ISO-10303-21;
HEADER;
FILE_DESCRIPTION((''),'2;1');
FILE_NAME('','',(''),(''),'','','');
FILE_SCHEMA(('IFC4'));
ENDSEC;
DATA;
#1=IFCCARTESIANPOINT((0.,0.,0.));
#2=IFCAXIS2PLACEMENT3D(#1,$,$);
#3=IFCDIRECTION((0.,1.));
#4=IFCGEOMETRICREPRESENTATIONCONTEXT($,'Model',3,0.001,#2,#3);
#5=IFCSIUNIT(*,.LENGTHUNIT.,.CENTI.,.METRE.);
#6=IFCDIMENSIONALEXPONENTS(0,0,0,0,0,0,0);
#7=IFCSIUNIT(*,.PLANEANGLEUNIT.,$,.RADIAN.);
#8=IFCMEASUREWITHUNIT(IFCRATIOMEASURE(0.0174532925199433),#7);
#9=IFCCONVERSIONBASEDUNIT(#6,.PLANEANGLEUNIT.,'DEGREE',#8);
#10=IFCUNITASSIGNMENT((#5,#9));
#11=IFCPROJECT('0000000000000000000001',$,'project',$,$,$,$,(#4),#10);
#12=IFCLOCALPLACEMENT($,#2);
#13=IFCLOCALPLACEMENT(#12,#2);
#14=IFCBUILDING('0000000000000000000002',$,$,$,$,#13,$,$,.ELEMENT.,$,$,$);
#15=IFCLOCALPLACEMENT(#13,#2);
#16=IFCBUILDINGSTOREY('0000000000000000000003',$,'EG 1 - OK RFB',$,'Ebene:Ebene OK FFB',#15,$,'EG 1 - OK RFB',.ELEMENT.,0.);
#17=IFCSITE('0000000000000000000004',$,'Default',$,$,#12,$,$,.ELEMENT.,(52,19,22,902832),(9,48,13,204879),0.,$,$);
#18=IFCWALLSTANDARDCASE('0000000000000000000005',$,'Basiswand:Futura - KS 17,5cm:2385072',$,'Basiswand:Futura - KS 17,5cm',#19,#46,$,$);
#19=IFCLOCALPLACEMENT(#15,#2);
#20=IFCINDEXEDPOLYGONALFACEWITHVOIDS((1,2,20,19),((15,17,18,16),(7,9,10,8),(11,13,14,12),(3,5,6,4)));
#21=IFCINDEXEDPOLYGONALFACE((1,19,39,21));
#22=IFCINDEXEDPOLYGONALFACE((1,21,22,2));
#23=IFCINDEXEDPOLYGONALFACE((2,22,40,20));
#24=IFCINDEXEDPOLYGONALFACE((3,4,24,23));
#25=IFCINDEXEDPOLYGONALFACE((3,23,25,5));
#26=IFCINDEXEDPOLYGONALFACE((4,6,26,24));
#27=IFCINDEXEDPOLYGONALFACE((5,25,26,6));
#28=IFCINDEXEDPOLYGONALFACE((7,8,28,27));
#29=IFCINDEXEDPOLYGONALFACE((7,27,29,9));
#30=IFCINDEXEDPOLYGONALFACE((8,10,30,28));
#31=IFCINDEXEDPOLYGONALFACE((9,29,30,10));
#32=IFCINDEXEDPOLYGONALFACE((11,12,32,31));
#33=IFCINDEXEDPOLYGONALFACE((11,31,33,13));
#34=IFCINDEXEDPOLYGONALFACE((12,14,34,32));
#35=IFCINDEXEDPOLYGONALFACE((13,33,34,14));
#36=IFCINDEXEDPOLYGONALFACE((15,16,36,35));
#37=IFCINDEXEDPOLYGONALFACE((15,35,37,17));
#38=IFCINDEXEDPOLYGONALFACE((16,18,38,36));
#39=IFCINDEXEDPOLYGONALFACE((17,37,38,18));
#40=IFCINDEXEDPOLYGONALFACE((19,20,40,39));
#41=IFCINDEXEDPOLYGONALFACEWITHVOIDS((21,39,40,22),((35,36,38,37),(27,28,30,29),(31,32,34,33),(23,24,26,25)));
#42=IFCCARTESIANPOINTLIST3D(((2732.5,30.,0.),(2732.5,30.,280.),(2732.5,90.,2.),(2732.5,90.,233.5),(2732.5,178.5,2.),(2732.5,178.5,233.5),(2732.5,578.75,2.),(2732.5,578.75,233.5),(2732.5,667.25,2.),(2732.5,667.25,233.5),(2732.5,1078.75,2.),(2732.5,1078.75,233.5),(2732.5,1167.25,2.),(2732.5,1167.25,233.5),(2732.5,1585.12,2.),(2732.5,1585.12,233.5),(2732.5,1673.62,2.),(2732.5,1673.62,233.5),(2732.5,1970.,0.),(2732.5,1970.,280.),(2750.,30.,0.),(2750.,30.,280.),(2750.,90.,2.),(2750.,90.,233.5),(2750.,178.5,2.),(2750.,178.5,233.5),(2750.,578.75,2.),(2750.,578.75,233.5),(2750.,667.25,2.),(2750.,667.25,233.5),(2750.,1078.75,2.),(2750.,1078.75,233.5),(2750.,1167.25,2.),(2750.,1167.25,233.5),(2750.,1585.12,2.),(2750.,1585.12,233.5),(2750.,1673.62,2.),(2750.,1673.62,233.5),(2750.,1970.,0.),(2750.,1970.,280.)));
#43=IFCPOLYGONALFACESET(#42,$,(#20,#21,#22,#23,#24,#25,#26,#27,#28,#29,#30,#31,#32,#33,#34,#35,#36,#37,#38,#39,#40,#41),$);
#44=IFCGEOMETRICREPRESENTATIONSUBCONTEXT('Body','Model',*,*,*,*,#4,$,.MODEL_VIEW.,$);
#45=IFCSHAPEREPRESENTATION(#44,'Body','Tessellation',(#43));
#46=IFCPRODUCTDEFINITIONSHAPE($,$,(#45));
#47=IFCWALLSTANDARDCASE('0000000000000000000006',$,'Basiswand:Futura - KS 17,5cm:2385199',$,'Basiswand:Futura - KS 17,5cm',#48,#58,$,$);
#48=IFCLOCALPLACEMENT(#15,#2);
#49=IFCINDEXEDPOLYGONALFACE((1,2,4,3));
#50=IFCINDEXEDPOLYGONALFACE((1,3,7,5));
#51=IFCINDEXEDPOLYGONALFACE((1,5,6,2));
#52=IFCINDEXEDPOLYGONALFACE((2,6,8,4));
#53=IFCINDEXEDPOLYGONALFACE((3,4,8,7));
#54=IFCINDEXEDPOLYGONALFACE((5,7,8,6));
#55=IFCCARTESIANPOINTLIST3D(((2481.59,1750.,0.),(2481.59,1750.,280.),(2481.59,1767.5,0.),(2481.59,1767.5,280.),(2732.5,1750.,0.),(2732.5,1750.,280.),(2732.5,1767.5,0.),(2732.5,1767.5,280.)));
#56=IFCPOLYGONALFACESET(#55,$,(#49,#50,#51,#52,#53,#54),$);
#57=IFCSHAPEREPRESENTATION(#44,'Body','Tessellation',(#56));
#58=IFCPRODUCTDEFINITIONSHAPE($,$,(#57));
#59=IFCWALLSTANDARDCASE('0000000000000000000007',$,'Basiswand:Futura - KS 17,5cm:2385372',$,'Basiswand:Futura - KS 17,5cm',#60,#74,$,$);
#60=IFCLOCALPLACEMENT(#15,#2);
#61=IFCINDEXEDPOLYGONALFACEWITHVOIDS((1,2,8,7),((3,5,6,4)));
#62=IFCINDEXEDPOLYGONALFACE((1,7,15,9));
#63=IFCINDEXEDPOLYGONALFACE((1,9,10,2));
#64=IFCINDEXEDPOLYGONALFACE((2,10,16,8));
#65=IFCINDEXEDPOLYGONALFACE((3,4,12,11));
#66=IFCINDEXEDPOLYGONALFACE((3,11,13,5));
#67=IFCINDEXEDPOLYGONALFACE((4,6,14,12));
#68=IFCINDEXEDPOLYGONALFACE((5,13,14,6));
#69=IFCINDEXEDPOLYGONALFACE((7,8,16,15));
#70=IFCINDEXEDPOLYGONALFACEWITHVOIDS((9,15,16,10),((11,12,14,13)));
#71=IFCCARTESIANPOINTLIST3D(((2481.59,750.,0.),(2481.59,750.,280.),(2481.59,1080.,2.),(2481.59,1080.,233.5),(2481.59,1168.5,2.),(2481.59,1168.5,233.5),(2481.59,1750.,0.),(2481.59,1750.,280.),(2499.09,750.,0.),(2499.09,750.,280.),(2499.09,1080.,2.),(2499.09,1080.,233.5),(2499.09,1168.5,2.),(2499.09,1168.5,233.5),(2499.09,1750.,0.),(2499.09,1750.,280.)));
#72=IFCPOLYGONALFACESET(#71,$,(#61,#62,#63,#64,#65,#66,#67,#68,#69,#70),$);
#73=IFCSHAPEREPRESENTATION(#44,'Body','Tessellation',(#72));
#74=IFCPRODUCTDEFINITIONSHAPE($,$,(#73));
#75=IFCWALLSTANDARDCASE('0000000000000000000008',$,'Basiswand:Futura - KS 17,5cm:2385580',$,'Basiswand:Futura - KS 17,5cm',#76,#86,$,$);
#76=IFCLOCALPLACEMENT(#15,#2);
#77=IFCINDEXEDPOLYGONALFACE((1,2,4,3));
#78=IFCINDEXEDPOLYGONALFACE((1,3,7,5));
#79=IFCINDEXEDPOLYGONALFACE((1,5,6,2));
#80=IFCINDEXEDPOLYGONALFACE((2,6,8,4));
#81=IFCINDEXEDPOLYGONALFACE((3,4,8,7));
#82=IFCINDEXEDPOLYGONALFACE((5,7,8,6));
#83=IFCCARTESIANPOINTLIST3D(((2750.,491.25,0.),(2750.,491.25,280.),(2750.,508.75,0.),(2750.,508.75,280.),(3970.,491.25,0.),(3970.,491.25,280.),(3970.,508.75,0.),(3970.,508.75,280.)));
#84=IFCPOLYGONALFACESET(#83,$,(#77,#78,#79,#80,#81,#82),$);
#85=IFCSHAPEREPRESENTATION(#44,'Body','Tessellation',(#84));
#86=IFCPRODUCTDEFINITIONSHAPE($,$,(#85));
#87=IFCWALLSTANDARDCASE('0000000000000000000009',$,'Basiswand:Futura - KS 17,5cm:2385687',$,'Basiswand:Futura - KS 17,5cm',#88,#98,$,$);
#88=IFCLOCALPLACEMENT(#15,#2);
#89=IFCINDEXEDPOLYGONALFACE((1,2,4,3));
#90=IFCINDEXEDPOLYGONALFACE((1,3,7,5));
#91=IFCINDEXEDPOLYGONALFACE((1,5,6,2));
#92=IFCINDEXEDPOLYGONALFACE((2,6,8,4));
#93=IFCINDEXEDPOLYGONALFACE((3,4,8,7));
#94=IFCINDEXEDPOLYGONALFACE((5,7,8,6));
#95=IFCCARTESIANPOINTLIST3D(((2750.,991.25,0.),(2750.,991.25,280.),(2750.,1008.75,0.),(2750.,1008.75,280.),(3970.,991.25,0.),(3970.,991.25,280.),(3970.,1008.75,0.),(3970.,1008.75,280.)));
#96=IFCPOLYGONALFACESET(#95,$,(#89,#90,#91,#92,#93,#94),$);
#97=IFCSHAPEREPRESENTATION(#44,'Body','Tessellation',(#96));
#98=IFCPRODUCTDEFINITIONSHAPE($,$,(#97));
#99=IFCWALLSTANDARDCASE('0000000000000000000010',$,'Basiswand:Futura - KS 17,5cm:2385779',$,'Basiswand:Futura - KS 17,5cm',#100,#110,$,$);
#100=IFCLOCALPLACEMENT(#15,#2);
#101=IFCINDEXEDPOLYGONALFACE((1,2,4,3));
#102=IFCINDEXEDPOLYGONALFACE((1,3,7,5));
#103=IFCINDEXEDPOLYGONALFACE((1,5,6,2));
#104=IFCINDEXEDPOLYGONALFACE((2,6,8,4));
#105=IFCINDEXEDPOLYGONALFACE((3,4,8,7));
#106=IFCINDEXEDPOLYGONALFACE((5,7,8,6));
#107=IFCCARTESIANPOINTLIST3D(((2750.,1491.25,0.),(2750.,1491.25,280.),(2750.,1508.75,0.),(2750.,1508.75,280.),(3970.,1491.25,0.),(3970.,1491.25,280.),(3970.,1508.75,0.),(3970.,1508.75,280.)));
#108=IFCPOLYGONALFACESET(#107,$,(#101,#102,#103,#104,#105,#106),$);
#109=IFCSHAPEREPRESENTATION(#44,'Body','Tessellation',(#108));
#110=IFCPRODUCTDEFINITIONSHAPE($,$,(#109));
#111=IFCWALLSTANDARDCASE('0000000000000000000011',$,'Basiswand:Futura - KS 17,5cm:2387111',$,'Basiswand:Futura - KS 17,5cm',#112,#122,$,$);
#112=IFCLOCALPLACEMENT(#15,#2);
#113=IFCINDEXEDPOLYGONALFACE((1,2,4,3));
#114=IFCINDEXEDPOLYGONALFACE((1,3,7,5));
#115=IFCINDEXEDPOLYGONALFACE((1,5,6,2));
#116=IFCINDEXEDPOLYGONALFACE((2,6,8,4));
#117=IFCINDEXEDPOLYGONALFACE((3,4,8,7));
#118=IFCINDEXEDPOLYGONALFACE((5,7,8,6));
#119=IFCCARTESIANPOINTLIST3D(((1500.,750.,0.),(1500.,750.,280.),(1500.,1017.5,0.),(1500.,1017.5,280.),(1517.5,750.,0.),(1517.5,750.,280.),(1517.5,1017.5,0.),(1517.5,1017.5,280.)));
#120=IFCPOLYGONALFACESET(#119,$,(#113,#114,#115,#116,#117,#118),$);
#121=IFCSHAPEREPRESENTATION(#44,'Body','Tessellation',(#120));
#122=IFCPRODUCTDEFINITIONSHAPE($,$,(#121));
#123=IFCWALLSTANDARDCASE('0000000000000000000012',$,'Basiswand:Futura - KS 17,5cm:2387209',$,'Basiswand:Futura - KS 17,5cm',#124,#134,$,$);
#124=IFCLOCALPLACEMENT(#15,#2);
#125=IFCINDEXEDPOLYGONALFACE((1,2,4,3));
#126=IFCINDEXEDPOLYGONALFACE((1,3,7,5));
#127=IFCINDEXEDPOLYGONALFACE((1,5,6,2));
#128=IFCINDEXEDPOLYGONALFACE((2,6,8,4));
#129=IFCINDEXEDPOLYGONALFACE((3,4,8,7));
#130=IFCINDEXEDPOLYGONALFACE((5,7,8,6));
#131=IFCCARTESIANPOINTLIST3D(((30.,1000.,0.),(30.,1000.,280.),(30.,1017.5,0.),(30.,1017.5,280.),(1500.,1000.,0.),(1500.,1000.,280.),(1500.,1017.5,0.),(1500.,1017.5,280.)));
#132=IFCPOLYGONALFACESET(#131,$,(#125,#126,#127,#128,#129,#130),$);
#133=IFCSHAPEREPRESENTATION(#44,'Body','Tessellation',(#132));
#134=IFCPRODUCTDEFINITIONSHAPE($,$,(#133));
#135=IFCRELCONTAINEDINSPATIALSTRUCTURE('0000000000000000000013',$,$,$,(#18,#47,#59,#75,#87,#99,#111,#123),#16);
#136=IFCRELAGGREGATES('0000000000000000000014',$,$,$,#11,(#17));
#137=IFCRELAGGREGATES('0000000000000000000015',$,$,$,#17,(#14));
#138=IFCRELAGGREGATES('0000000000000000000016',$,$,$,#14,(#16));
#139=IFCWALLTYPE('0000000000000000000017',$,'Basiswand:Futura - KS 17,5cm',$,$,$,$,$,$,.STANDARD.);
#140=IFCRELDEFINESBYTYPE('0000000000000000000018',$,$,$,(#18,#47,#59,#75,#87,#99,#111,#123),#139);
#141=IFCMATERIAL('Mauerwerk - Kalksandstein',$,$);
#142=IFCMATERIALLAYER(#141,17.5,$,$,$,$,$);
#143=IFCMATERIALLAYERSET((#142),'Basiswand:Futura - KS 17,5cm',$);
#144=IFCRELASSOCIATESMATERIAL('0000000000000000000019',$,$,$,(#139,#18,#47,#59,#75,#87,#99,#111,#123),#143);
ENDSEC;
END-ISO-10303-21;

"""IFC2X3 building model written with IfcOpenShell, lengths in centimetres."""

from ifc_helpers import new_model, entity, si_unit, converted_unit, direction, frame, frame_2d, origin, place, context, subcontext, project, spatial, rectangle, extrude, material, layer, layer_set, layer_usage, type_object, element, save


model = new_model("IFC2X3")

# Units and contexts
model_context = context("Model", 3, precision=0.001, world=origin(), true_north=direction((0.0, 1.0)))
body_context = subcontext(model_context, "Body", "Model", "MODEL_VIEW")
ifc_project = project(units=[si_unit("LENGTHUNIT", "METRE", prefix="CENTI"), converted_unit("PLANEANGLEUNIT", "DEGREE", entity("IfcRatioMeasure", 0.0174532925199433), si_unit("PLANEANGLEUNIT", "RADIAN"), dimensions=[0, 0, 0, 0, 0, 0, 0])], contexts=[model_context])

# Site, building, storey
site_placement = place(None, frame((0.0, 0.0, 0.0)))
site = spatial("IfcSite", under=ifc_project, at=site_placement, Name="Default", CompositionType="ELEMENT", RefLatitude=(52, 19, 22, 902832), RefLongitude=(9, 48, 13, 204879), RefElevation=0.0)
building_placement = place(site_placement, origin())
building = spatial("IfcBuilding", under=site, at=building_placement, CompositionType="ELEMENT")
storey_placement = place(building_placement, origin())
storey = spatial("IfcBuildingStorey", under=building, at=storey_placement, Name="EG 1 - OK RFB", ObjectType="Ebene:Ebene OK FFB", LongName="EG 1 - OK RFB", CompositionType="ELEMENT", Elevation=0.0)

# Shared definitions
ifc_material_1 = material(Name="Mauerwerk - Kalksandstein")
ifc_layer_1 = layer(ifc_material_1, 17.5)
ifc_layer_set_1 = layer_set([ifc_layer_1], Name="Basiswand:Futura - KS 17,5cm")
wall_type_1 = type_object("IfcWallType", Name="Basiswand:Futura - KS 17,5cm", PredefinedType="STANDARD", material=ifc_layer_set_1)

# Wall, openings
ifc_layer_usage_1 = layer_usage(ifc_layer_set_1, "AXIS2", "NEGATIVE", 8.75)
wall_1_placement = place(storey_placement, frame((2741.25, 1970.0, 0.0), z_axis=(0.0, 0.0, 1.0), x_axis=(0.0, -1.0, 0.0)))
wall_1 = element("IfcWallStandardCase", 1, at=wall_1_placement, inside=storey, type_object=wall_type_1, material=ifc_layer_usage_1, Name="Basiswand:Futura - KS 17,5cm:2385072", ObjectType="Basiswand:Futura - KS 17,5cm", context=body_context, shape_type="SweptSolid", body=[
    extrude(rectangle(XDim=1940.0, YDim=17.5, at=frame_2d((970.0, 0.0), x_axis=(-1.0, 0.0))), origin(), (0.0, 0.0, 1.0), 280.0),
])
opening_1_placement = place(wall_1_placement, frame((296.37, -8.75, 2.0)))
element("IfcOpeningElement", 2, at=opening_1_placement, cuts=wall_1, ObjectType="Opening", context=body_context, shape_type="SweptSolid", body=[
    extrude(rectangle(XDim=231.5, YDim=88.5, at=frame_2d((115.75, 44.25), x_axis=(-1.0, 0.0))), frame((0.0, 0.0, 0.0), z_axis=(0.0, 1.0, 0.0), x_axis=(0.0, 0.0, 1.0)), (0.0, 0.0, 1.0), 17.5),
])
opening_2_placement = place(wall_1_placement, frame((802.75, -8.75, 2.0)))
element("IfcOpeningElement", 3, at=opening_2_placement, cuts=wall_1, ObjectType="Opening", context=body_context, shape_type="SweptSolid", body=[
    extrude(rectangle(XDim=231.5, YDim=88.5, at=frame_2d((115.75, 44.25), x_axis=(-1.0, 0.0))), frame((0.0, 0.0, 0.0), z_axis=(0.0, 1.0, 0.0), x_axis=(0.0, 0.0, 1.0)), (0.0, 0.0, 1.0), 17.5),
])
opening_3_placement = place(wall_1_placement, frame((1302.75, -8.75, 2.0)))
element("IfcOpeningElement", 4, at=opening_3_placement, cuts=wall_1, ObjectType="Opening", context=body_context, shape_type="SweptSolid", body=[
    extrude(rectangle(XDim=231.5, YDim=88.5, at=frame_2d((115.75, 44.25), x_axis=(-1.0, 0.0))), frame((0.0, 0.0, 0.0), z_axis=(0.0, 1.0, 0.0), x_axis=(0.0, 0.0, 1.0)), (0.0, 0.0, 1.0), 17.5),
])
opening_4_placement = place(wall_1_placement, frame((1791.5, -8.75, 2.0)))
element("IfcOpeningElement", 5, at=opening_4_placement, cuts=wall_1, ObjectType="Opening", context=body_context, shape_type="SweptSolid", body=[
    extrude(rectangle(XDim=231.5, YDim=88.5, at=frame_2d((115.75, 44.25), x_axis=(-1.0, 0.0))), frame((0.0, 0.0, 0.0), z_axis=(0.0, 1.0, 0.0), x_axis=(0.0, 0.0, 1.0)), (0.0, 0.0, 1.0), 17.5),
])

# Wall
ifc_layer_usage_2 = layer_usage(ifc_layer_set_1, "AXIS2", "NEGATIVE", 8.75)
wall_2_placement = place(storey_placement, frame((2732.5, 1758.75, 0.0), z_axis=(0.0, 0.0, 1.0), x_axis=(-1.0, 0.0, 0.0)))
element("IfcWallStandardCase", 6, at=wall_2_placement, inside=storey, type_object=wall_type_1, material=ifc_layer_usage_2, Name="Basiswand:Futura - KS 17,5cm:2385199", ObjectType="Basiswand:Futura - KS 17,5cm", context=body_context, shape_type="SweptSolid", body=[
    extrude(rectangle(XDim=250.9, YDim=17.5, at=frame_2d((125.45, 0.0), x_axis=(-1.0, 0.0))), origin(), (0.0, 0.0, 1.0), 280.0),
])

# Wall, opening
ifc_layer_usage_3 = layer_usage(ifc_layer_set_1, "AXIS2", "NEGATIVE", 8.75)
wall_3_placement = place(storey_placement, frame((2490.34, 750.0, 0.0), z_axis=(0.0, 0.0, 1.0), x_axis=(0.0, 1.0, 0.0)))
wall_3 = element("IfcWallStandardCase", 7, at=wall_3_placement, inside=storey, type_object=wall_type_1, material=ifc_layer_usage_3, Name="Basiswand:Futura - KS 17,5cm:2385372", ObjectType="Basiswand:Futura - KS 17,5cm", context=body_context, shape_type="SweptSolid", body=[
    extrude(rectangle(XDim=1000.0, YDim=17.5, at=frame_2d((500.0, 0.0), x_axis=(-1.0, 0.0))), origin(), (0.0, 0.0, 1.0), 280.0),
])
opening_5_placement = place(wall_3_placement, frame((330.0, -8.75, 2.0)))
element("IfcOpeningElement", 8, at=opening_5_placement, cuts=wall_3, ObjectType="Opening", context=body_context, shape_type="SweptSolid", body=[
    extrude(rectangle(XDim=231.5, YDim=88.5, at=frame_2d((115.75, 44.25), x_axis=(-1.0, 0.0))), frame((0.0, 0.0, 0.0), z_axis=(0.0, 1.0, 0.0), x_axis=(0.0, 0.0, 1.0)), (0.0, 0.0, 1.0), 17.5),
])

# Walls
ifc_layer_usage_4 = layer_usage(ifc_layer_set_1, "AXIS2", "NEGATIVE", 8.75)
wall_4_placement = place(storey_placement, frame((2750.0, 500.0, 0.0)))
element("IfcWallStandardCase", 9, at=wall_4_placement, inside=storey, type_object=wall_type_1, material=ifc_layer_usage_4, Name="Basiswand:Futura - KS 17,5cm:2385580", ObjectType="Basiswand:Futura - KS 17,5cm", context=body_context, shape_type="SweptSolid", body=[
    extrude(rectangle(XDim=1220.0, YDim=17.5, at=frame_2d((610.0, 0.0), x_axis=(-1.0, 0.0))), origin(), (0.0, 0.0, 1.0), 280.0),
])
ifc_layer_usage_5 = layer_usage(ifc_layer_set_1, "AXIS2", "NEGATIVE", 8.75)
wall_5_placement = place(storey_placement, frame((2750.0, 1000.0, 0.0)))
element("IfcWallStandardCase", 10, at=wall_5_placement, inside=storey, type_object=wall_type_1, material=ifc_layer_usage_5, Name="Basiswand:Futura - KS 17,5cm:2385687", ObjectType="Basiswand:Futura - KS 17,5cm", context=body_context, shape_type="SweptSolid", body=[
    extrude(rectangle(XDim=1220.0, YDim=17.5, at=frame_2d((610.0, 0.0), x_axis=(-1.0, 0.0))), origin(), (0.0, 0.0, 1.0), 280.0),
])
ifc_layer_usage_6 = layer_usage(ifc_layer_set_1, "AXIS2", "NEGATIVE", 8.75)
wall_6_placement = place(storey_placement, frame((2750.0, 1500.0, 0.0)))
element("IfcWallStandardCase", 11, at=wall_6_placement, inside=storey, type_object=wall_type_1, material=ifc_layer_usage_6, Name="Basiswand:Futura - KS 17,5cm:2385779", ObjectType="Basiswand:Futura - KS 17,5cm", context=body_context, shape_type="SweptSolid", body=[
    extrude(rectangle(XDim=1220.0, YDim=17.5, at=frame_2d((610.0, 0.0), x_axis=(-1.0, 0.0))), origin(), (0.0, 0.0, 1.0), 280.0),
])
ifc_layer_usage_7 = layer_usage(ifc_layer_set_1, "AXIS2", "NEGATIVE", 8.75)
wall_7_placement = place(storey_placement, frame((1508.75, 750.0, 0.0), z_axis=(0.0, 0.0, 1.0), x_axis=(0.0, 1.0, 0.0)))
element("IfcWallStandardCase", 12, at=wall_7_placement, inside=storey, type_object=wall_type_1, material=ifc_layer_usage_7, Name="Basiswand:Futura - KS 17,5cm:2387111", ObjectType="Basiswand:Futura - KS 17,5cm", context=body_context, shape_type="SweptSolid", body=[
    extrude(rectangle(XDim=267.5, YDim=17.5, at=frame_2d((133.75, 0.0), x_axis=(-1.0, 0.0))), origin(), (0.0, 0.0, 1.0), 280.0),
])
ifc_layer_usage_8 = layer_usage(ifc_layer_set_1, "AXIS2", "NEGATIVE", 8.75)
wall_8_placement = place(storey_placement, frame((1500.0, 1008.75, 0.0), z_axis=(0.0, 0.0, 1.0), x_axis=(-1.0, 0.0, 0.0)))
element("IfcWallStandardCase", 13, at=wall_8_placement, inside=storey, type_object=wall_type_1, material=ifc_layer_usage_8, Name="Basiswand:Futura - KS 17,5cm:2387209", ObjectType="Basiswand:Futura - KS 17,5cm", context=body_context, shape_type="SweptSolid", body=[
    extrude(rectangle(XDim=1470.0, YDim=17.5, at=frame_2d((735.0, 0.0), x_axis=(-1.0, 0.0))), origin(), (0.0, 0.0, 1.0), 280.0),
])

save(model, "model.ifc")
